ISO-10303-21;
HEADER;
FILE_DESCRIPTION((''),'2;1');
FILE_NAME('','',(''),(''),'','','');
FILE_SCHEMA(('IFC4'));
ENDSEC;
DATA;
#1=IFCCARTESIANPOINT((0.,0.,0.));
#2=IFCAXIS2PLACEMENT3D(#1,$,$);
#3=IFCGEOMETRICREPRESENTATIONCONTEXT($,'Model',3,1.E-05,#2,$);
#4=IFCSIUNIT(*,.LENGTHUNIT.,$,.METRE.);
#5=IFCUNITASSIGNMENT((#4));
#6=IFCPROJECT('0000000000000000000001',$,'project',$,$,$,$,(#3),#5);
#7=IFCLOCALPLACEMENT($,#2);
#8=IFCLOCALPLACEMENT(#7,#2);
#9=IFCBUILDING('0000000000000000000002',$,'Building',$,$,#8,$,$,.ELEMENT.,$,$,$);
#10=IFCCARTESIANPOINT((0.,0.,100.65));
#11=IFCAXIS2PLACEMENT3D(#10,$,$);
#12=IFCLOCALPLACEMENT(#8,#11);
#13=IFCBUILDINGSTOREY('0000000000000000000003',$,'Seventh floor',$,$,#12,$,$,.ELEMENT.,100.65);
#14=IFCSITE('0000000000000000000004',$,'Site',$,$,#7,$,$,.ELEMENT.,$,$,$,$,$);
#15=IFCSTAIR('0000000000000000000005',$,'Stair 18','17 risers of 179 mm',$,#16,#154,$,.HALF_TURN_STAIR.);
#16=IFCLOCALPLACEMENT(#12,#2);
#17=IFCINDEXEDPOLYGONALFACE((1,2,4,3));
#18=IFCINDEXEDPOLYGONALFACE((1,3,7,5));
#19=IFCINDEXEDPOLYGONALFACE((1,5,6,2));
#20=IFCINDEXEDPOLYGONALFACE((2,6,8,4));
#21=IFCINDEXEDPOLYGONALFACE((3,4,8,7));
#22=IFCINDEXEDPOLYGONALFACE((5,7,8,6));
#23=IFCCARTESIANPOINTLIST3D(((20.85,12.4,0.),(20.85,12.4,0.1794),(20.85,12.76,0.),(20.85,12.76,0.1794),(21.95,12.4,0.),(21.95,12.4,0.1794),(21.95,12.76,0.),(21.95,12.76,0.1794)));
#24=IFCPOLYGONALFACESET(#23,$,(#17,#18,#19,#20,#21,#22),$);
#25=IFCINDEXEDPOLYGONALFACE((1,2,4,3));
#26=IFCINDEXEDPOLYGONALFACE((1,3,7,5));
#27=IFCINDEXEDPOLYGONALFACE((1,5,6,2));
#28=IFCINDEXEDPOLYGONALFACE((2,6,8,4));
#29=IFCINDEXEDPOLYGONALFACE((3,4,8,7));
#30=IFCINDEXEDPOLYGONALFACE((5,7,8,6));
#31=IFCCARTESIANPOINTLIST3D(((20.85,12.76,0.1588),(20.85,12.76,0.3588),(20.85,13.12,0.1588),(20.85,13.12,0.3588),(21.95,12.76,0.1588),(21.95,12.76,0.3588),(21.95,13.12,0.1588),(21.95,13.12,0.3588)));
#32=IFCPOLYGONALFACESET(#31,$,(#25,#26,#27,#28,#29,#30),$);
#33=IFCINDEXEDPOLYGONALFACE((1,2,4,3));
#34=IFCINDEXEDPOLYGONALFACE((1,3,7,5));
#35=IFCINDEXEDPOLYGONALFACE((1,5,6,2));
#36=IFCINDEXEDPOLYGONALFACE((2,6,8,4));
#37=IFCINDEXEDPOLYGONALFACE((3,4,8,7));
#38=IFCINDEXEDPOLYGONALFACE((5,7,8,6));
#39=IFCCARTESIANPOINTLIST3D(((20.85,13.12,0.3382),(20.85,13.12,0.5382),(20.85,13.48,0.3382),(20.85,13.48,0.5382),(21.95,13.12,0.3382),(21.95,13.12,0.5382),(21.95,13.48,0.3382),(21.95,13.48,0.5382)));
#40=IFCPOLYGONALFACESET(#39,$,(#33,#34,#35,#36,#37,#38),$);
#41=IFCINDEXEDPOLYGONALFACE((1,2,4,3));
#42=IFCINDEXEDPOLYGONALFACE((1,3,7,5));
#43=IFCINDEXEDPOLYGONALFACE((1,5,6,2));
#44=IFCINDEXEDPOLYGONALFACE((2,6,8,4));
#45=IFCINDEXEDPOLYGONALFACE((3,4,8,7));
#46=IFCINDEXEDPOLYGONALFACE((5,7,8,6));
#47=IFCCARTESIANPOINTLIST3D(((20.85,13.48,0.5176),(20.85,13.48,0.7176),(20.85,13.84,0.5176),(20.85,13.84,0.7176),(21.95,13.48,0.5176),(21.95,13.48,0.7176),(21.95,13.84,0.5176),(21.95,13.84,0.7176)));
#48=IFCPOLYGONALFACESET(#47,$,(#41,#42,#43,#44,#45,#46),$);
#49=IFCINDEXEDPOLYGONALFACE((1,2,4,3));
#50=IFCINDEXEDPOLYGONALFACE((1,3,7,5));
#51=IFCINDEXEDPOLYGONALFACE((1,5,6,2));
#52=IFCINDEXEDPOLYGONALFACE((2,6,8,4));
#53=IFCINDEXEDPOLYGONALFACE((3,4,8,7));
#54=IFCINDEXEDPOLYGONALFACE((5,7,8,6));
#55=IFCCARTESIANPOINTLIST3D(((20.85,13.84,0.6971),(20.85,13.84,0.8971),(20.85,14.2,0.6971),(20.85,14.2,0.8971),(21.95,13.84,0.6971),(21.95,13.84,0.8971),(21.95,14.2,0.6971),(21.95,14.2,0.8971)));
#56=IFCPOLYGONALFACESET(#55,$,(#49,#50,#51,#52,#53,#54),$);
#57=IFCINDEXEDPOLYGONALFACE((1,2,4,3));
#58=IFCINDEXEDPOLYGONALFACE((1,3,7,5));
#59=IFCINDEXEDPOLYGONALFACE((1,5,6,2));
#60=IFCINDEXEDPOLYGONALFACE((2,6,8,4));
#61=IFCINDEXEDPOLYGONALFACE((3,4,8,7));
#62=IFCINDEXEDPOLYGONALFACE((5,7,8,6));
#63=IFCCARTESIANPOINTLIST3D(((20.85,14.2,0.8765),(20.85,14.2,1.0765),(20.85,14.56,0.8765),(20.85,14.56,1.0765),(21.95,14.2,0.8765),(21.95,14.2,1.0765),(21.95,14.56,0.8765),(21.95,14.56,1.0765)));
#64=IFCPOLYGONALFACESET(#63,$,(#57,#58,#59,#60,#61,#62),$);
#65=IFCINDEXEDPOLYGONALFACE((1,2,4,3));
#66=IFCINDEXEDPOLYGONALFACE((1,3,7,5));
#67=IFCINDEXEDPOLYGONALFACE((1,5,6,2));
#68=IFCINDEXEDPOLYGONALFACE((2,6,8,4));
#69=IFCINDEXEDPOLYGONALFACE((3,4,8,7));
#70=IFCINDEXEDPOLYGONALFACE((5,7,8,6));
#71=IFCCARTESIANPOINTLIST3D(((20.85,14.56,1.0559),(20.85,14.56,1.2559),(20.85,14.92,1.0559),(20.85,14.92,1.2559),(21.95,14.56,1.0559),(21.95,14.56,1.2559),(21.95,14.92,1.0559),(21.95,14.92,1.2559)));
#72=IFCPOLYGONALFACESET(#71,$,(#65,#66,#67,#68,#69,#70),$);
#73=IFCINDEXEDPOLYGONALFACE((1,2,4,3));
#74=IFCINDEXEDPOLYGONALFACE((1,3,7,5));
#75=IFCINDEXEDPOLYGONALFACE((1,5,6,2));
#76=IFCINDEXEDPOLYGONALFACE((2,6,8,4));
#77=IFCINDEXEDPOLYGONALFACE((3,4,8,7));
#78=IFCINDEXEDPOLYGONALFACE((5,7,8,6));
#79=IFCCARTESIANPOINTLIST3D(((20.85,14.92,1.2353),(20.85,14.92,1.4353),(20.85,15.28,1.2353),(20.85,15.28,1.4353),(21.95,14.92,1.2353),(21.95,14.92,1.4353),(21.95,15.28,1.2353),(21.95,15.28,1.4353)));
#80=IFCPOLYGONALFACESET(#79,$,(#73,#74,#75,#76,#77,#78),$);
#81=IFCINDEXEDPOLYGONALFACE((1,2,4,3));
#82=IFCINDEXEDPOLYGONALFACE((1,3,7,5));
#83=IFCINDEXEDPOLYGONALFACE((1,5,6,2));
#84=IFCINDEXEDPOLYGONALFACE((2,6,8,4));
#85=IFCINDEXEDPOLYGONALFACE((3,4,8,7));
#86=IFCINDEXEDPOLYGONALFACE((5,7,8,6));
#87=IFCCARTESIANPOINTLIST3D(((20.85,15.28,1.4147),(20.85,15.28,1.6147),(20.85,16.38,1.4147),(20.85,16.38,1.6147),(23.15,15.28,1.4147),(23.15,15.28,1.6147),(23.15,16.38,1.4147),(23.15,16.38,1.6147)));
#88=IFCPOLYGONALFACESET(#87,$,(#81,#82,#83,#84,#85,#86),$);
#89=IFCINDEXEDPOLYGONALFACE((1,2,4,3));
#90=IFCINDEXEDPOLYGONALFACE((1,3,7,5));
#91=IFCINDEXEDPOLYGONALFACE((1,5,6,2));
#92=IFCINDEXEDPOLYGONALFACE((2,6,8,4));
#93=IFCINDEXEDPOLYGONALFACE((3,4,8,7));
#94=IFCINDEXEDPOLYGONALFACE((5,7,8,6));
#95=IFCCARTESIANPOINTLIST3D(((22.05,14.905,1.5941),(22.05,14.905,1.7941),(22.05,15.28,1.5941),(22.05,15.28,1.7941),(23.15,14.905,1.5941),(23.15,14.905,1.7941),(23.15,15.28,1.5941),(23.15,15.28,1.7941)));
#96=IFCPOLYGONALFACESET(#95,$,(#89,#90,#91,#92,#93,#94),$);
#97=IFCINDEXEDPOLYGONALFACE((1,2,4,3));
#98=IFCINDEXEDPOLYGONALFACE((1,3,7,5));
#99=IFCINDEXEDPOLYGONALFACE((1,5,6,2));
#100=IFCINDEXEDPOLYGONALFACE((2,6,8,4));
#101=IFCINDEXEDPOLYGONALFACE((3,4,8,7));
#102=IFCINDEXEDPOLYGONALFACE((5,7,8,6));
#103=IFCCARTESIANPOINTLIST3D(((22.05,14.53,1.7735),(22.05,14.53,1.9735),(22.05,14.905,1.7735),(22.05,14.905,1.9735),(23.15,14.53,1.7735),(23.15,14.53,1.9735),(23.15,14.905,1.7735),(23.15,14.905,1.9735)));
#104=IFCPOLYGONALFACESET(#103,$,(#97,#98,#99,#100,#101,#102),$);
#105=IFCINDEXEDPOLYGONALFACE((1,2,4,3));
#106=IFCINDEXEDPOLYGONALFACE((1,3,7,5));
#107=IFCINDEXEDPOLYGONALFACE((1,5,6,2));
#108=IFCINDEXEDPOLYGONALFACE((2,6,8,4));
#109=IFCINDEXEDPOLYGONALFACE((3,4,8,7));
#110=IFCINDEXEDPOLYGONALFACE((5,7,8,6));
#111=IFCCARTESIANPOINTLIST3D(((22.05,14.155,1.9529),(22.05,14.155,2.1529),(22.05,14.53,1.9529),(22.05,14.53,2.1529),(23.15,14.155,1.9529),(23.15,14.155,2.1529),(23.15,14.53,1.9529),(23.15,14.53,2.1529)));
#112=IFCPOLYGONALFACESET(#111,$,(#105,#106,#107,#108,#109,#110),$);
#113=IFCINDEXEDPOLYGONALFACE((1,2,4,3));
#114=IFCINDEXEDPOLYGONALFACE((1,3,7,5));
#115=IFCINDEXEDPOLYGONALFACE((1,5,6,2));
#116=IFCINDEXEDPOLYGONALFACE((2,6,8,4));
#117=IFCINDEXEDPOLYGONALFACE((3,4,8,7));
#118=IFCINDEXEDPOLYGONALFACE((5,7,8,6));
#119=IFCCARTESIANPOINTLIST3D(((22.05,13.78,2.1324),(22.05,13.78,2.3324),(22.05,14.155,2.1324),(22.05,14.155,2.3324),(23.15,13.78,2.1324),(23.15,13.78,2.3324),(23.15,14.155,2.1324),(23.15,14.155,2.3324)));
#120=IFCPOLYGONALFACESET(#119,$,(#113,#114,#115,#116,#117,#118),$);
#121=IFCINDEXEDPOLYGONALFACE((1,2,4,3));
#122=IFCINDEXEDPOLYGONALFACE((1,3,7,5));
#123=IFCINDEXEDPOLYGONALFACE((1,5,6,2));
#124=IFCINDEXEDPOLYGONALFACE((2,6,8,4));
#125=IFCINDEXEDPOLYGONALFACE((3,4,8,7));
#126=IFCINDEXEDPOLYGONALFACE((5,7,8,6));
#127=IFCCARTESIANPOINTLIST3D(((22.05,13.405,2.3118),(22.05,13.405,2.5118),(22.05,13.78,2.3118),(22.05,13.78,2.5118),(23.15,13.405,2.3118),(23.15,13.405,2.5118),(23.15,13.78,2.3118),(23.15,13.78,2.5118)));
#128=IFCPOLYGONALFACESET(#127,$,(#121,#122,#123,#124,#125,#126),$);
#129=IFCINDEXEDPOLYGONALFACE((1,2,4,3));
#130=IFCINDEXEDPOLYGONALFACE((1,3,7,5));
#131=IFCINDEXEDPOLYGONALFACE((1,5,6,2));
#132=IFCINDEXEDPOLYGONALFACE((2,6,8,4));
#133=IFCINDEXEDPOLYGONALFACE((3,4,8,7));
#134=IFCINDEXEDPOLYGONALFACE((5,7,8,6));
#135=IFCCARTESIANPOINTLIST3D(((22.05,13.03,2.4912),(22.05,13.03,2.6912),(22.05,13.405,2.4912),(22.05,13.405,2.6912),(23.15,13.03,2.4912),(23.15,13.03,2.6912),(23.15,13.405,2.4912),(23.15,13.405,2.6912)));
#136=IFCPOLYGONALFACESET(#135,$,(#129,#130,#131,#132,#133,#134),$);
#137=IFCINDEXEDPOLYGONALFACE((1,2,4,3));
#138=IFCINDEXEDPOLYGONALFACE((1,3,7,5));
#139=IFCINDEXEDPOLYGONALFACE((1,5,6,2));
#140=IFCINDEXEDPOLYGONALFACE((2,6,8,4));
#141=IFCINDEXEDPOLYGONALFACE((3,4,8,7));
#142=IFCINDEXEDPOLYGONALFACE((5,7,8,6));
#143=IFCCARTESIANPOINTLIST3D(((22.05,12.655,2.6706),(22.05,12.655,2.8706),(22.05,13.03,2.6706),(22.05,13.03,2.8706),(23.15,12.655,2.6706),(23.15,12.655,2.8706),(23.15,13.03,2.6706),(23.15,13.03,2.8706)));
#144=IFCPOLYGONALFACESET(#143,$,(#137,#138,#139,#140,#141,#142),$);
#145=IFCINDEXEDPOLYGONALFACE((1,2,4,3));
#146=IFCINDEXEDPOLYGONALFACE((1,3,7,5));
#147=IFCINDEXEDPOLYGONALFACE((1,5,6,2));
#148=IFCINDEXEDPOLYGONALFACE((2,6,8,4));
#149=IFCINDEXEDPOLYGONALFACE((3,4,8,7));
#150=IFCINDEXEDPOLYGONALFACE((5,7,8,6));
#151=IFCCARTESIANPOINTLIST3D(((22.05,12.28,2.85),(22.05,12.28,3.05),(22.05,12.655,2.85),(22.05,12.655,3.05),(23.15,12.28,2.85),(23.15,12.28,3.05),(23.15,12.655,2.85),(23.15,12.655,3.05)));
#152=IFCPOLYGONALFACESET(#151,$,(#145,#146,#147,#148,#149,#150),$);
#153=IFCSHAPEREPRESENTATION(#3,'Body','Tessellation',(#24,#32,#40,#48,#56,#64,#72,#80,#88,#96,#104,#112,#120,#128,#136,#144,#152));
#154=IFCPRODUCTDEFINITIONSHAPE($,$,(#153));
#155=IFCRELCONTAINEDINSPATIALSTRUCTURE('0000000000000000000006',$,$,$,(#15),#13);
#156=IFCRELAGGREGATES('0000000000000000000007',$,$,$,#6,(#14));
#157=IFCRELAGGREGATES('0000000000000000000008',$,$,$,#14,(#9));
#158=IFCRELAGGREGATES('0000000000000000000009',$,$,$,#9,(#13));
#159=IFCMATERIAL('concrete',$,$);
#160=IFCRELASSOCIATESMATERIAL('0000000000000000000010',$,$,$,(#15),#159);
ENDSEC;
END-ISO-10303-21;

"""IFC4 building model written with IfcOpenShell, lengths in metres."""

from ifc_helpers import new_model, si_unit, frame, origin, place, context, project, spatial, polyline, outline, extrude, material, element, save


model = new_model("IFC4")

# Units and contexts
model_context = context("Model", 3, precision=1e-05, world=origin())
ifc_project = project(units=[si_unit("LENGTHUNIT", "METRE")], contexts=[model_context])

# Site, building, storey
site_placement = place(None, origin())
site = spatial("IfcSite", under=ifc_project, at=site_placement, Name="Site", CompositionType="ELEMENT")
building_placement = place(site_placement, origin())
building = spatial("IfcBuilding", under=site, at=building_placement, Name="Building", CompositionType="ELEMENT")
storey_placement = place(building_placement, frame((0.0, 0.0, 100.65)))
storey = spatial("IfcBuildingStorey", under=building, at=storey_placement, Name="Seventh floor", CompositionType="ELEMENT", Elevation=100.65)

# Shared definitions
ifc_material = material(Name="concrete")

# Stair
stair_1_placement = place(storey_placement, frame((21.4, 12.4, 0.0), z_axis=(0.0, 0.0, 1.0), x_axis=(0.0, 1.0, 0.0)))
element("IfcStair", 1, at=stair_1_placement, inside=storey, material=ifc_material, Name="Stair 18", Description="17 risers of 179 mm", PredefinedType="HALF_TURN_STAIR", context=model_context, shape_type="SweptSolid", body=[
    extrude(outline(polyline([(0.0, -0.55), (0.36, -0.55), (0.36, 0.55), (0.0, 0.55), (0.0, -0.55)])), origin(), (0.0, 0.0, 1.0), 0.1794),
    extrude(outline(polyline([(0.36, -0.55), (0.72, -0.55), (0.72, 0.55), (0.36, 0.55), (0.36, -0.55)])), frame((0.0, 0.0, 0.1588)), (0.0, 0.0, 1.0), 0.2),
    extrude(outline(polyline([(0.72, -0.55), (1.08, -0.55), (1.08, 0.55), (0.72, 0.55), (0.72, -0.55)])), frame((0.0, 0.0, 0.3382)), (0.0, 0.0, 1.0), 0.2),
    extrude(outline(polyline([(1.08, -0.55), (1.44, -0.55), (1.44, 0.55), (1.08, 0.55), (1.08, -0.55)])), frame((0.0, 0.0, 0.5176)), (0.0, 0.0, 1.0), 0.2),
    extrude(outline(polyline([(1.44, -0.55), (1.8, -0.55), (1.8, 0.55), (1.44, 0.55), (1.44, -0.55)])), frame((0.0, 0.0, 0.6971)), (0.0, 0.0, 1.0), 0.2),
    extrude(outline(polyline([(1.8, -0.55), (2.16, -0.55), (2.16, 0.55), (1.8, 0.55), (1.8, -0.55)])), frame((0.0, 0.0, 0.8765)), (0.0, 0.0, 1.0), 0.2),
    extrude(outline(polyline([(2.16, -0.55), (2.52, -0.55), (2.52, 0.55), (2.16, 0.55), (2.16, -0.55)])), frame((0.0, 0.0, 1.0559)), (0.0, 0.0, 1.0), 0.2),
    extrude(outline(polyline([(2.52, -0.55), (2.88, -0.55), (2.88, 0.55), (2.52, 0.55), (2.52, -0.55)])), frame((0.0, 0.0, 1.2353)), (0.0, 0.0, 1.0), 0.2),
    extrude(outline(polyline([(2.88, -1.75), (3.98, -1.75), (3.98, 0.55), (2.88, 0.55), (2.88, -1.75)])), frame((0.0, 0.0, 1.4147)), (0.0, 0.0, 1.0), 0.2),
    extrude(outline(polyline([(2.505, -1.75), (2.88, -1.75), (2.88, -0.65), (2.505, -0.65), (2.505, -1.75)])), frame((0.0, 0.0, 1.5941)), (0.0, 0.0, 1.0), 0.2),
    extrude(outline(polyline([(2.13, -1.75), (2.505, -1.75), (2.505, -0.65), (2.13, -0.65), (2.13, -1.75)])), frame((0.0, 0.0, 1.7735)), (0.0, 0.0, 1.0), 0.2),
    extrude(outline(polyline([(1.755, -1.75), (2.13, -1.75), (2.13, -0.65), (1.755, -0.65), (1.755, -1.75)])), frame((0.0, 0.0, 1.9529)), (0.0, 0.0, 1.0), 0.2),
    extrude(outline(polyline([(1.38, -1.75), (1.755, -1.75), (1.755, -0.65), (1.38, -0.65), (1.38, -1.75)])), frame((0.0, 0.0, 2.1324)), (0.0, 0.0, 1.0), 0.2),
    extrude(outline(polyline([(1.005, -1.75), (1.38, -1.75), (1.38, -0.65), (1.005, -0.65), (1.005, -1.75)])), frame((0.0, 0.0, 2.3118)), (0.0, 0.0, 1.0), 0.2),
    extrude(outline(polyline([(0.63, -1.75), (1.005, -1.75), (1.005, -0.65), (0.63, -0.65), (0.63, -1.75)])), frame((0.0, 0.0, 2.4912)), (0.0, 0.0, 1.0), 0.2),
    extrude(outline(polyline([(0.255, -1.75), (0.63, -1.75), (0.63, -0.65), (0.255, -0.65), (0.255, -1.75)])), frame((0.0, 0.0, 2.6706)), (0.0, 0.0, 1.0), 0.2),
    extrude(outline(polyline([(-0.12, -1.75), (0.255, -1.75), (0.255, -0.65), (-0.12, -0.65), (-0.12, -1.75)])), frame((0.0, 0.0, 2.85)), (0.0, 0.0, 1.0), 0.2),
])

save(model, "model.ifc")
